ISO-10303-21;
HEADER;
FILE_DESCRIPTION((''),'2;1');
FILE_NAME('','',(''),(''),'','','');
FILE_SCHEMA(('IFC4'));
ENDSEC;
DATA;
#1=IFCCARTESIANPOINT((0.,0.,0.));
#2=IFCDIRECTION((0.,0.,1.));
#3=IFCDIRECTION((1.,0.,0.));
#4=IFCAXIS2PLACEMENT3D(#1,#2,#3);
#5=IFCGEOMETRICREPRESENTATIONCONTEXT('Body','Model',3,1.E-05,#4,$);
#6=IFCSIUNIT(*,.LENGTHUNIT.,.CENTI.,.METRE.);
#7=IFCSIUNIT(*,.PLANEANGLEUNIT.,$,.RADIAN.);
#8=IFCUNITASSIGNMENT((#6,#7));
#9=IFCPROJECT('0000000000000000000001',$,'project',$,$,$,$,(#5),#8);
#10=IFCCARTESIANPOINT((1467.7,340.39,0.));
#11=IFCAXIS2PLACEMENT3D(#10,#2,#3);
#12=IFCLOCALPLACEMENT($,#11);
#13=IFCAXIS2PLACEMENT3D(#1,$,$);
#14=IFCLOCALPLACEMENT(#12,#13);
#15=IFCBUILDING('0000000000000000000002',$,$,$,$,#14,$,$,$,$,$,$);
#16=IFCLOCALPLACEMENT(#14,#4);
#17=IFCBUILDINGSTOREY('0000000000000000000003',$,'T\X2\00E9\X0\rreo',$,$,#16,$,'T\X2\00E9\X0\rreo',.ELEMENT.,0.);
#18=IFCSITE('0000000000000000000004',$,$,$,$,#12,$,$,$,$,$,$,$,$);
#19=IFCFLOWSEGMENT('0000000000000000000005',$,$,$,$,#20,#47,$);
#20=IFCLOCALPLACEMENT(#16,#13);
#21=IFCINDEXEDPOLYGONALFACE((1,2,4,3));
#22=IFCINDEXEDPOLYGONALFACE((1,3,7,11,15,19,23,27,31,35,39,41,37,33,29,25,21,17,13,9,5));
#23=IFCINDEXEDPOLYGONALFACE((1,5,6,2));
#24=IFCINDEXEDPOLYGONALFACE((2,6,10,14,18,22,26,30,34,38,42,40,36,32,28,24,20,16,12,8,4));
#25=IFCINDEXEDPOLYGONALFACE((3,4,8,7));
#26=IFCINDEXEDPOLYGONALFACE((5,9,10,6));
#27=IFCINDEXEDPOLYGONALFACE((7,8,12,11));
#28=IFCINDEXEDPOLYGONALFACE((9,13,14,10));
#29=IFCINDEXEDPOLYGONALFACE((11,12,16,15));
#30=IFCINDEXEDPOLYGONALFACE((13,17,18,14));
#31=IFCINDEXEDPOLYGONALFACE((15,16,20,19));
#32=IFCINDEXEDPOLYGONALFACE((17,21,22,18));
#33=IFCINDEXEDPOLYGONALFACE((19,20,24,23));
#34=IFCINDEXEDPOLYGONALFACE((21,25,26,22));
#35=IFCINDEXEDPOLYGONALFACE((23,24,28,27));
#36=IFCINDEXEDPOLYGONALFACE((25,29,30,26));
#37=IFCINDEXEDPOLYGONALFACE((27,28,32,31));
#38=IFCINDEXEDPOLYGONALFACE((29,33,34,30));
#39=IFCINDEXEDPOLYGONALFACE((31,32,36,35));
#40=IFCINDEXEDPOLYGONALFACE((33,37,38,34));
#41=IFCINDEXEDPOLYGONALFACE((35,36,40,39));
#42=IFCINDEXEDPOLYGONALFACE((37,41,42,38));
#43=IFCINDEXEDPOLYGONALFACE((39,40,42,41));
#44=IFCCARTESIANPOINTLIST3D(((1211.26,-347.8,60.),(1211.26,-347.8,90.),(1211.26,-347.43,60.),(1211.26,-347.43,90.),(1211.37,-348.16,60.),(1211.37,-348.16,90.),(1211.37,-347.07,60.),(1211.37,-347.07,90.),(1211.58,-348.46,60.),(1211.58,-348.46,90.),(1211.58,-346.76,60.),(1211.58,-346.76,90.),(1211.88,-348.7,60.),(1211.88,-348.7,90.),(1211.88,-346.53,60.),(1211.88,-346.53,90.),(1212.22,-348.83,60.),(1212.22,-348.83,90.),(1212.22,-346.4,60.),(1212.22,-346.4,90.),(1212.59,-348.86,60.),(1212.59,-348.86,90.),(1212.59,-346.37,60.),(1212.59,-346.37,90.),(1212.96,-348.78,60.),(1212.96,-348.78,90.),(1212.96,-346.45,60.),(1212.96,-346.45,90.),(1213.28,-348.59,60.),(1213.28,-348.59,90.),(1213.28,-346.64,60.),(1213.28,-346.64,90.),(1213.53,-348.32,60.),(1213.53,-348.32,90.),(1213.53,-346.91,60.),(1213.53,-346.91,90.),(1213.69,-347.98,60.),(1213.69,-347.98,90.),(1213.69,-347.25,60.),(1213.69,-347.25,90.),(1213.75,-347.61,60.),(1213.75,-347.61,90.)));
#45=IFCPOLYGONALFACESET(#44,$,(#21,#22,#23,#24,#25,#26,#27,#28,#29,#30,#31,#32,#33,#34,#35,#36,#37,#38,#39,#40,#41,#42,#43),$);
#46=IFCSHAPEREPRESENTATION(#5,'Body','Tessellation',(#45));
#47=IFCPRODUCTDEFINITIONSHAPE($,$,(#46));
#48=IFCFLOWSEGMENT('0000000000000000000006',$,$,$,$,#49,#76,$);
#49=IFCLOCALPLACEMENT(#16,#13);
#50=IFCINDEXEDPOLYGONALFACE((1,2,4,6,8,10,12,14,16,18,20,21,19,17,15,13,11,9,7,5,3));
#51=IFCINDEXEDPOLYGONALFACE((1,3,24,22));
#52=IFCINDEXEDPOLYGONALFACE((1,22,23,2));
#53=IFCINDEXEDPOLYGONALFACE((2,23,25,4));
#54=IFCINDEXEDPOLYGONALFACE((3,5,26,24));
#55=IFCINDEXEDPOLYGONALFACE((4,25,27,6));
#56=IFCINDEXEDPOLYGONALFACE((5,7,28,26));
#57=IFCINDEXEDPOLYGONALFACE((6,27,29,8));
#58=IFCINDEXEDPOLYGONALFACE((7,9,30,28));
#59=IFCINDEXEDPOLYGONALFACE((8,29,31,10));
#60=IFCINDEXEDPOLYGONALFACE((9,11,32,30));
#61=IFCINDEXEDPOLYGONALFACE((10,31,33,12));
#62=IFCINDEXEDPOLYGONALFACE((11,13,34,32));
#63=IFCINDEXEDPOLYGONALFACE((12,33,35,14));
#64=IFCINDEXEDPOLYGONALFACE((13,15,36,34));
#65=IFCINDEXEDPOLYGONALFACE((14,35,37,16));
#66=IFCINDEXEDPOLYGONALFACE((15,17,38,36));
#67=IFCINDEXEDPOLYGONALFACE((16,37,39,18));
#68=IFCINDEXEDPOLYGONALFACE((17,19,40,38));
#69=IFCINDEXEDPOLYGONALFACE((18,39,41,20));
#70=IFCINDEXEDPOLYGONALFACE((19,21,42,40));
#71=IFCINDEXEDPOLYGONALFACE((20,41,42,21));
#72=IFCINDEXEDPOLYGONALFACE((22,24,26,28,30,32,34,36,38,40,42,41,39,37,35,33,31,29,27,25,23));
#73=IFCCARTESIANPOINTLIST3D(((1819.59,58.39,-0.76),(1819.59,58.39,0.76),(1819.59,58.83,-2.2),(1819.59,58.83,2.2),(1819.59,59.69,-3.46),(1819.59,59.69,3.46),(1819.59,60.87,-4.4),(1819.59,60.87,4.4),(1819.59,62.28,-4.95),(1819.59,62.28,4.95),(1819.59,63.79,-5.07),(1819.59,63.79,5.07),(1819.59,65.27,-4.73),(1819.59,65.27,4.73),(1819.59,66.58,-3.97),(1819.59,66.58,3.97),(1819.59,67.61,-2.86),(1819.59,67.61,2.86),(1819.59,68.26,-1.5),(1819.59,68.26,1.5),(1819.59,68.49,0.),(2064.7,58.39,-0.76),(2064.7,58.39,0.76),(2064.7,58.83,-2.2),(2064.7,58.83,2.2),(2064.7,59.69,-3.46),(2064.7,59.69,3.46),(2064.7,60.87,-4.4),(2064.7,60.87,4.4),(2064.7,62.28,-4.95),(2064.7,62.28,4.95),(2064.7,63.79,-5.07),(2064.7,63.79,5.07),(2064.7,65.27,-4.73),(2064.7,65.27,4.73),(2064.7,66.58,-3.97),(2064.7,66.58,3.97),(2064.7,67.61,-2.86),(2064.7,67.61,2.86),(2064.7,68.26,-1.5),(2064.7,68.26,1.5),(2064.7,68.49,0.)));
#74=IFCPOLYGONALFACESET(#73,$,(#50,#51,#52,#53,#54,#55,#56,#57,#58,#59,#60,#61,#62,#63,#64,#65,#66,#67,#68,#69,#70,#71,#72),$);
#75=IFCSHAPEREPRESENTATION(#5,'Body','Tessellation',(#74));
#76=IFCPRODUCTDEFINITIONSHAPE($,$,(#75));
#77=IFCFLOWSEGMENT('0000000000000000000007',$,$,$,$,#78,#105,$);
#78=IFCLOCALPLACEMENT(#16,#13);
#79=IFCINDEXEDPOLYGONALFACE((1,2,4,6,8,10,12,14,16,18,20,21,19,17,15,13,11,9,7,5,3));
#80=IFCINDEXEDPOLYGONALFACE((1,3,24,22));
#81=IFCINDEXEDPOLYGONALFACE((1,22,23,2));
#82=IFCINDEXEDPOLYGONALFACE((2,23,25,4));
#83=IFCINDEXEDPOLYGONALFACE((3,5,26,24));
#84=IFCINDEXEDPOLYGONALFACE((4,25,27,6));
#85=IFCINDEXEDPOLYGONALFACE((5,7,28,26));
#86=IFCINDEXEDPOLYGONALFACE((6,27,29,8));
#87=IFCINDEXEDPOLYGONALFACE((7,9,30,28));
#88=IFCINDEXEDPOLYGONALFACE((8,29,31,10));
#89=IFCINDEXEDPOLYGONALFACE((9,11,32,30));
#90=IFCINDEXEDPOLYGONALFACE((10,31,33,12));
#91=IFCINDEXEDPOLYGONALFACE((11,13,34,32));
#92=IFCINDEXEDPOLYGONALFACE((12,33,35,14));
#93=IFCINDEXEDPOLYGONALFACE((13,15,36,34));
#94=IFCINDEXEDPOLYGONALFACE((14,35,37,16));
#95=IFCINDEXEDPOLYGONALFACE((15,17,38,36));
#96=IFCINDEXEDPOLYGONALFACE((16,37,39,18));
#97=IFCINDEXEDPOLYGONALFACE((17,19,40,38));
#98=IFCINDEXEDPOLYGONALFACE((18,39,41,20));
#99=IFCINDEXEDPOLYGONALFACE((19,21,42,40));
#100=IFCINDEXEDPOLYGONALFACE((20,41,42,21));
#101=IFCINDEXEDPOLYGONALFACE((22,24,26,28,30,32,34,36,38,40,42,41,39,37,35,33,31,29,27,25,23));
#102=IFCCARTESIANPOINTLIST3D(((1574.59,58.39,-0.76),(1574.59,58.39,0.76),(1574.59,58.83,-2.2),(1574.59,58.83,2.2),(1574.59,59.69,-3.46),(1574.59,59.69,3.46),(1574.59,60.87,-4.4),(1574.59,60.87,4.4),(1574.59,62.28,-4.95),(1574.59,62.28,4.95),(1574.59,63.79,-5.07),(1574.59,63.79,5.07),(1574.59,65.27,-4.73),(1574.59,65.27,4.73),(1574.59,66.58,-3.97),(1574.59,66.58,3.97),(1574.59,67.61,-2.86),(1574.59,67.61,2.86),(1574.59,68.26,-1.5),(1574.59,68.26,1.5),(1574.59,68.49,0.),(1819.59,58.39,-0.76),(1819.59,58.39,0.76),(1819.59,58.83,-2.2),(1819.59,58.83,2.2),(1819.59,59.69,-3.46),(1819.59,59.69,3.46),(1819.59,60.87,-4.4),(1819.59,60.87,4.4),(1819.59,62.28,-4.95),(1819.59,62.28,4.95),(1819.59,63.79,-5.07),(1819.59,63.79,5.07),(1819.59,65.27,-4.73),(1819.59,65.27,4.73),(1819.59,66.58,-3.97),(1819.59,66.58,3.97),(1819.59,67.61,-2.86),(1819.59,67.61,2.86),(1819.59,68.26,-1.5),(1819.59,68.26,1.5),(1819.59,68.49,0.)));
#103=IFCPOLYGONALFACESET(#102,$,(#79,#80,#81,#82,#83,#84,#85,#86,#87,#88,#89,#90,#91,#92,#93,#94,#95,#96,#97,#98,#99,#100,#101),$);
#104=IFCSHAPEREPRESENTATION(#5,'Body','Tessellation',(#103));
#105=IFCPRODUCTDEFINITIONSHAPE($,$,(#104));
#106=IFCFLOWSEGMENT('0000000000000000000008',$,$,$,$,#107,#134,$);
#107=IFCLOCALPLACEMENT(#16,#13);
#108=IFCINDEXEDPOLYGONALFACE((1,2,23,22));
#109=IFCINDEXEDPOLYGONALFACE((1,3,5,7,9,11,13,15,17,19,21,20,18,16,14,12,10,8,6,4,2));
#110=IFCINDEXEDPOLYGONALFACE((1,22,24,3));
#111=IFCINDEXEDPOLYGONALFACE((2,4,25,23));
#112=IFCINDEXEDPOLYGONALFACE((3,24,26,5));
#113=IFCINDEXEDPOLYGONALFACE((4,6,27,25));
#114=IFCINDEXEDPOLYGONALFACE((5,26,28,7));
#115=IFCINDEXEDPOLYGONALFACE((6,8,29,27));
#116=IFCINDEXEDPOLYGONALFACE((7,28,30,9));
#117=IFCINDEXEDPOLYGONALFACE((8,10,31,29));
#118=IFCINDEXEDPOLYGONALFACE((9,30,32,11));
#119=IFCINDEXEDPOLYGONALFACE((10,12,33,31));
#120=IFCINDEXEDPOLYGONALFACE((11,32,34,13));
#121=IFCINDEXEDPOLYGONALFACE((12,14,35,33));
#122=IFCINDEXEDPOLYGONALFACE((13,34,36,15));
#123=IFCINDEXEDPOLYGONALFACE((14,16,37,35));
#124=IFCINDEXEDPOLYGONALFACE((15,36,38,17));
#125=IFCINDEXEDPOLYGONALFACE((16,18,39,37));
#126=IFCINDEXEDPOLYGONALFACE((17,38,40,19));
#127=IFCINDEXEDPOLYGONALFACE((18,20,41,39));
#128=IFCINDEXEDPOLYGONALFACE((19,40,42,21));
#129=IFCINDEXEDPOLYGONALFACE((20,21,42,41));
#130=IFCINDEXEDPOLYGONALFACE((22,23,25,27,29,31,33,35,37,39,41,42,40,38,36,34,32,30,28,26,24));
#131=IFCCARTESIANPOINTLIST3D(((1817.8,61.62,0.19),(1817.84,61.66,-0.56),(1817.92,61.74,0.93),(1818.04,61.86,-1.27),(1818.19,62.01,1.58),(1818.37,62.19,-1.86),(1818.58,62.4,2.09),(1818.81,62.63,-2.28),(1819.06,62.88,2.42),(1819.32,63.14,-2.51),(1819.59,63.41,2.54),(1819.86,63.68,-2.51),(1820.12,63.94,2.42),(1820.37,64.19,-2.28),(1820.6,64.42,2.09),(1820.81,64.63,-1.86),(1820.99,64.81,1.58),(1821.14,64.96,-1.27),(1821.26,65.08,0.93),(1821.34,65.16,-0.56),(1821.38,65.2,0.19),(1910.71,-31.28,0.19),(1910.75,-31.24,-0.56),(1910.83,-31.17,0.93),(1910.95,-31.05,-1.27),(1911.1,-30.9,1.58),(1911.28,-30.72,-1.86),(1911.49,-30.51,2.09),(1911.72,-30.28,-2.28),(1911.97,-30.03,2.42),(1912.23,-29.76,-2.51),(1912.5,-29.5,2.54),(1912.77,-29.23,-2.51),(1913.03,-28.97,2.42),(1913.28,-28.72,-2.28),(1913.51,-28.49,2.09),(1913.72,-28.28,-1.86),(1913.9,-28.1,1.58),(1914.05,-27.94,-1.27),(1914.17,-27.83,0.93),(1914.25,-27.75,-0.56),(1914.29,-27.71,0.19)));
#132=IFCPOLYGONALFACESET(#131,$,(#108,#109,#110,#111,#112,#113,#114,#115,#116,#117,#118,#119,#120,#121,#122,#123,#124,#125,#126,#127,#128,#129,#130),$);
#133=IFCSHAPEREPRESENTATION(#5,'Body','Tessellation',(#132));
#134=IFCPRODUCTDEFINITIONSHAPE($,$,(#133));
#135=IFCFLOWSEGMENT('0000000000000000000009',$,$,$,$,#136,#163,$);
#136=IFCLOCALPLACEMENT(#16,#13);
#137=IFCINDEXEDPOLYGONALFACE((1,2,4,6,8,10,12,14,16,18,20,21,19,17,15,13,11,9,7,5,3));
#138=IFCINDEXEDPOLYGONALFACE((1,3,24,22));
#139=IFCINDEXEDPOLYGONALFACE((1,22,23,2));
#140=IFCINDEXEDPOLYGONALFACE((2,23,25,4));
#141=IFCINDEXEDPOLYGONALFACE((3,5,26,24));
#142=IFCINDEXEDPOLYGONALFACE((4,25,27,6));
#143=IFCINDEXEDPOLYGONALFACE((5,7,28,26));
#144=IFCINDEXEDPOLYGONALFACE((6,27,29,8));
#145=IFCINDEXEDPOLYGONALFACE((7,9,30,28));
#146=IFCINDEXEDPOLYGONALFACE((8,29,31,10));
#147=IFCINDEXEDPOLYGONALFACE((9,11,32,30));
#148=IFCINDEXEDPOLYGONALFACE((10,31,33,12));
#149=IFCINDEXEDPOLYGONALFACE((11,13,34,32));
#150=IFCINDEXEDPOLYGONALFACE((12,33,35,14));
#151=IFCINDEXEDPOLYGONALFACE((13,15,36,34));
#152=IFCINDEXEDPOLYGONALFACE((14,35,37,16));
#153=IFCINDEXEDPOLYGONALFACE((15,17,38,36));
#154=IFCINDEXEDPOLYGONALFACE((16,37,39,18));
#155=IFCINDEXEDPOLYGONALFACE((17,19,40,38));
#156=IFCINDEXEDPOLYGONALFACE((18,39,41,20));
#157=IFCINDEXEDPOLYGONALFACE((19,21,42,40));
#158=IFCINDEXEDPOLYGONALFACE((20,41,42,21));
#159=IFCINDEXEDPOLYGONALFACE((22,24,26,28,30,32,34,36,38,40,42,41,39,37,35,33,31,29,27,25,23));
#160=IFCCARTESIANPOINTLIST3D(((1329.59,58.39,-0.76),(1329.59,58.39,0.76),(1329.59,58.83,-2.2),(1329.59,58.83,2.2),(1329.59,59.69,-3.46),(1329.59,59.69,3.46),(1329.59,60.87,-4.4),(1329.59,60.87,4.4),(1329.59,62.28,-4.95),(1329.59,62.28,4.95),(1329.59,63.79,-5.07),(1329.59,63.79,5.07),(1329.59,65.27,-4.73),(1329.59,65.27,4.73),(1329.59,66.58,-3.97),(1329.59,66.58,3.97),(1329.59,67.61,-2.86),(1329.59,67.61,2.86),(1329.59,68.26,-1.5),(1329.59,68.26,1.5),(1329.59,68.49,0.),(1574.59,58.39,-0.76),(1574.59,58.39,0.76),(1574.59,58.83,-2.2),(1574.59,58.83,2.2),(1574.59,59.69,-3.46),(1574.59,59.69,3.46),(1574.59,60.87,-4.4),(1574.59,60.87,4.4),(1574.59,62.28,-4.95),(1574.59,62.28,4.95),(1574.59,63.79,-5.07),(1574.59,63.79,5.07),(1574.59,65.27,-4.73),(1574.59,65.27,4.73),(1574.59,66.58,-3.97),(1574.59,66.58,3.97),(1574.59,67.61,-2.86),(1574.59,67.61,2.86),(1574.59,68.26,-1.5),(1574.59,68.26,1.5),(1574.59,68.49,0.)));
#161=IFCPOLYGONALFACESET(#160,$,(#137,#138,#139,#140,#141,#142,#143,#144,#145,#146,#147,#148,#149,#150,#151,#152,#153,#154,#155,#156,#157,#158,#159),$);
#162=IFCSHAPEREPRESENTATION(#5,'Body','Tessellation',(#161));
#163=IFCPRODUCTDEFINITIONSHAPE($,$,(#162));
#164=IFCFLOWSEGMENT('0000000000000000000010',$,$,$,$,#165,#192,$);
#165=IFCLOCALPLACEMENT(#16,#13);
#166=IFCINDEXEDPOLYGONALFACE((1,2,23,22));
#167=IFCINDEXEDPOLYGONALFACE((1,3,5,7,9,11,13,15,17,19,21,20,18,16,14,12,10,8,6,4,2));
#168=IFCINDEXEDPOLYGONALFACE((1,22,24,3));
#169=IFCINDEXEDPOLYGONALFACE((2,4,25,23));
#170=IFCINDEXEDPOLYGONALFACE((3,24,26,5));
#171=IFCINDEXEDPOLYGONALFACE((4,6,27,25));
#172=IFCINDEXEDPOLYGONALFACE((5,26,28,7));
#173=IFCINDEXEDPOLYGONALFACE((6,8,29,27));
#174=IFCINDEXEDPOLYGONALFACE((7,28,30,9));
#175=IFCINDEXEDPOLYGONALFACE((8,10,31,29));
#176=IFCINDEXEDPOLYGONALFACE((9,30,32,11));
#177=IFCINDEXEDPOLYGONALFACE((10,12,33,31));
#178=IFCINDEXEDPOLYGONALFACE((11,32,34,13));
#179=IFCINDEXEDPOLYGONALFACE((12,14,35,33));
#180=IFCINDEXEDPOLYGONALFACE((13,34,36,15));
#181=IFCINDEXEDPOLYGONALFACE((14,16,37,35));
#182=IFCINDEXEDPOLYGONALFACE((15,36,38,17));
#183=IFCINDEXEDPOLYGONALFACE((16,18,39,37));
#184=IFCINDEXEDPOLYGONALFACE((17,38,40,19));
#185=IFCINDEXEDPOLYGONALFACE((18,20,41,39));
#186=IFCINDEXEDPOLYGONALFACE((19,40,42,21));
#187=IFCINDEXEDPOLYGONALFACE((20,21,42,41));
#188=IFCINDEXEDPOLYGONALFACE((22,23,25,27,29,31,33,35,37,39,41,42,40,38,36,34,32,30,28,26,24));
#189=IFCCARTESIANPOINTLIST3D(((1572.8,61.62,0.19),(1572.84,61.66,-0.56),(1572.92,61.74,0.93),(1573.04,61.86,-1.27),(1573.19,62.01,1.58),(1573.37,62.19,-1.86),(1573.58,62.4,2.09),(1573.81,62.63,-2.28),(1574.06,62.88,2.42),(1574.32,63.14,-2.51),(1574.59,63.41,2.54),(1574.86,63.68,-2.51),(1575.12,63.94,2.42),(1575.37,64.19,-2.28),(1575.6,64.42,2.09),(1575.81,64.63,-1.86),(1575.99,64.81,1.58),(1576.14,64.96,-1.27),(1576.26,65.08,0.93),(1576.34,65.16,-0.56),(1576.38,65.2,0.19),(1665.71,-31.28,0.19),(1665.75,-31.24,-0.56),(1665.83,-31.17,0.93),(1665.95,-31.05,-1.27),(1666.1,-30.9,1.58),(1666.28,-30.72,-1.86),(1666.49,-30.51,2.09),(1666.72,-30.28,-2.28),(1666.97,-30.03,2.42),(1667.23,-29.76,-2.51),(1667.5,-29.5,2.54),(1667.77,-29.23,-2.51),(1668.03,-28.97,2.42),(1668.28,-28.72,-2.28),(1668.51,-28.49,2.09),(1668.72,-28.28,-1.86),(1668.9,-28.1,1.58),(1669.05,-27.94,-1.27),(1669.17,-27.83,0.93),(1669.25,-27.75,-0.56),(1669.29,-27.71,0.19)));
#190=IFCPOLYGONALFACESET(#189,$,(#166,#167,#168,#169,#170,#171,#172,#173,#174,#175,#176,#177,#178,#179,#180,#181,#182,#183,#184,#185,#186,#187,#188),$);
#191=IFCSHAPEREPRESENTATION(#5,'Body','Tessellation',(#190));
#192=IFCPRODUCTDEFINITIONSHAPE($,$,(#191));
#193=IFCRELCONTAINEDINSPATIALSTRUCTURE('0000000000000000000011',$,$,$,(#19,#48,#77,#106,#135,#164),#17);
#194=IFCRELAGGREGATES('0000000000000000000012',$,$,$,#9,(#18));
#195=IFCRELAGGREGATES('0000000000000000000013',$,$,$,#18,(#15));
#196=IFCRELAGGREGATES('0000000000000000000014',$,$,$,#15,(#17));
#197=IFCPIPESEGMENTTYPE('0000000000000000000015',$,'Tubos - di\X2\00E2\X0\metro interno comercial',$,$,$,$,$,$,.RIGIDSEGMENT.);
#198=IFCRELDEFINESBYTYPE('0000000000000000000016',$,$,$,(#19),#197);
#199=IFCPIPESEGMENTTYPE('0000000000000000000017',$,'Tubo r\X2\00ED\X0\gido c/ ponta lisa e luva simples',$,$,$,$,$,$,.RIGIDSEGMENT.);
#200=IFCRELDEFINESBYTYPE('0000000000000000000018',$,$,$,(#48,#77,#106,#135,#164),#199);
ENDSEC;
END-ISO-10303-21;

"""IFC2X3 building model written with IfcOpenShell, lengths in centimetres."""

from ifc_helpers import new_model, si_unit, frame, origin, origin_with_axes, origin_2d_with_axis, place, context, project, spatial, circle, extrude, type_object, element, save


model = new_model("IFC2X3")

# Units and contexts
model_context = context("Model", 3, precision=1e-05, world=origin_with_axes(), identifier="Body")
ifc_project = project(units=[si_unit("LENGTHUNIT", "METRE", prefix="CENTI"), si_unit("PLANEANGLEUNIT", "RADIAN")], contexts=[model_context])

# Site, building, storey
site_placement = place(None, frame((1467.7, 340.39, 0.0), z_axis=(0.0, 0.0, 1.0), x_axis=(1.0, 0.0, 0.0)))
site = spatial("IfcSite", under=ifc_project, at=site_placement)
building_placement = place(site_placement, origin())
building = spatial("IfcBuilding", under=site, at=building_placement)
storey_placement = place(building_placement, origin_with_axes())
storey = spatial("IfcBuildingStorey", under=building, at=storey_placement, Name="Térreo", LongName="Térreo", CompositionType="ELEMENT", Elevation=0.0)

# Flow segments
pipe_segment_type_1 = type_object("IfcPipeSegmentType", Name="Tubos - diâmetro interno comercial", PredefinedType="RIGIDSEGMENT")
for number, where, z_axis, x_axis in (
    (1, (1212.5, -347.61, 90.0), (0.0, 0.0, 1.0), (1.0, 0.0, 0.0)),
):
    element("IfcFlowSegment", number, at=place(storey_placement, frame(where, z_axis=z_axis, x_axis=x_axis)), inside=storey, type_object=pipe_segment_type_1, context=model_context, shape_type="SolidModel", body=[
        extrude(circle(Radius=1.25, at=origin_2d_with_axis()), frame((0.0, 0.0, 0.0), z_axis=(0.0, 0.0, -1.0), x_axis=(1.0, 0.0, 0.0)), (0.0, 0.0, 1.0), 30.0),
    ])
pipe_segment_type_2 = type_object("IfcPipeSegmentType", Name="Tubo rígido c/ ponta lisa e luva simples", PredefinedType="RIGIDSEGMENT")
flow_segment_1_placement = place(storey_placement, frame((1942.14, 63.41, 5.08), z_axis=(0.0, 0.0, 1.0), x_axis=(1.0, 0.0, 0.0)))
element("IfcFlowSegment", 2, at=flow_segment_1_placement, inside=storey, type_object=pipe_segment_type_2, context=model_context, shape_type="SolidModel", body=[
    extrude(circle(Radius=5.08, at=origin_2d_with_axis()), frame((122.55, 0.0, -5.08), z_axis=(-1.0, 0.0, 0.0), x_axis=(0.0, 1.0, 0.0)), (0.0, 0.0, 1.0), 245.1),
])
flow_segment_2_placement = place(storey_placement, frame((1697.09, 63.41, 5.08), z_axis=(0.0, 0.0, 1.0), x_axis=(1.0, 0.0, 0.0)))
element("IfcFlowSegment", 3, at=flow_segment_2_placement, inside=storey, type_object=pipe_segment_type_2, context=model_context, shape_type="SolidModel", body=[
    extrude(circle(Radius=5.08, at=origin_2d_with_axis()), frame((122.5, 0.0, -5.08), z_axis=(-1.0, 0.0, 0.0), x_axis=(0.0, 1.0, 0.0)), (0.0, 0.0, 1.0), 245.0),
])
flow_segment_3_placement = place(storey_placement, frame((1866.05, 16.96, 2.54), z_axis=(0.0, 0.0, 1.0), x_axis=(1.0, 0.0, 0.0)))
element("IfcFlowSegment", 4, at=flow_segment_3_placement, inside=storey, type_object=pipe_segment_type_2, context=model_context, shape_type="SolidModel", body=[
    extrude(circle(Radius=2.54, at=origin_2d_with_axis()), frame((46.45, -46.45, -2.54), z_axis=(-0.707107, 0.707107, 0.0), x_axis=(0.0, 0.0, 1.0)), (0.0, 0.0, 1.0), 131.39),
])
flow_segment_4_placement = place(storey_placement, frame((1452.09, 63.41, 5.08), z_axis=(0.0, 0.0, 1.0), x_axis=(1.0, 0.0, 0.0)))
element("IfcFlowSegment", 5, at=flow_segment_4_placement, inside=storey, type_object=pipe_segment_type_2, context=model_context, shape_type="SolidModel", body=[
    extrude(circle(Radius=5.08, at=origin_2d_with_axis()), frame((122.5, 0.0, -5.08), z_axis=(-1.0, 0.0, 0.0), x_axis=(0.0, 1.0, 0.0)), (0.0, 0.0, 1.0), 245.0),
])
flow_segment_5_placement = place(storey_placement, frame((1621.05, 16.96, 2.54), z_axis=(0.0, 0.0, 1.0), x_axis=(1.0, 0.0, 0.0)))
element("IfcFlowSegment", 6, at=flow_segment_5_placement, inside=storey, type_object=pipe_segment_type_2, context=model_context, shape_type="SolidModel", body=[
    extrude(circle(Radius=2.54, at=origin_2d_with_axis()), frame((46.45, -46.45, -2.54), z_axis=(-0.707107, 0.707107, 0.0), x_axis=(0.0, 0.0, 1.0)), (0.0, 0.0, 1.0), 131.39),
])

save(model, "model.ifc")
